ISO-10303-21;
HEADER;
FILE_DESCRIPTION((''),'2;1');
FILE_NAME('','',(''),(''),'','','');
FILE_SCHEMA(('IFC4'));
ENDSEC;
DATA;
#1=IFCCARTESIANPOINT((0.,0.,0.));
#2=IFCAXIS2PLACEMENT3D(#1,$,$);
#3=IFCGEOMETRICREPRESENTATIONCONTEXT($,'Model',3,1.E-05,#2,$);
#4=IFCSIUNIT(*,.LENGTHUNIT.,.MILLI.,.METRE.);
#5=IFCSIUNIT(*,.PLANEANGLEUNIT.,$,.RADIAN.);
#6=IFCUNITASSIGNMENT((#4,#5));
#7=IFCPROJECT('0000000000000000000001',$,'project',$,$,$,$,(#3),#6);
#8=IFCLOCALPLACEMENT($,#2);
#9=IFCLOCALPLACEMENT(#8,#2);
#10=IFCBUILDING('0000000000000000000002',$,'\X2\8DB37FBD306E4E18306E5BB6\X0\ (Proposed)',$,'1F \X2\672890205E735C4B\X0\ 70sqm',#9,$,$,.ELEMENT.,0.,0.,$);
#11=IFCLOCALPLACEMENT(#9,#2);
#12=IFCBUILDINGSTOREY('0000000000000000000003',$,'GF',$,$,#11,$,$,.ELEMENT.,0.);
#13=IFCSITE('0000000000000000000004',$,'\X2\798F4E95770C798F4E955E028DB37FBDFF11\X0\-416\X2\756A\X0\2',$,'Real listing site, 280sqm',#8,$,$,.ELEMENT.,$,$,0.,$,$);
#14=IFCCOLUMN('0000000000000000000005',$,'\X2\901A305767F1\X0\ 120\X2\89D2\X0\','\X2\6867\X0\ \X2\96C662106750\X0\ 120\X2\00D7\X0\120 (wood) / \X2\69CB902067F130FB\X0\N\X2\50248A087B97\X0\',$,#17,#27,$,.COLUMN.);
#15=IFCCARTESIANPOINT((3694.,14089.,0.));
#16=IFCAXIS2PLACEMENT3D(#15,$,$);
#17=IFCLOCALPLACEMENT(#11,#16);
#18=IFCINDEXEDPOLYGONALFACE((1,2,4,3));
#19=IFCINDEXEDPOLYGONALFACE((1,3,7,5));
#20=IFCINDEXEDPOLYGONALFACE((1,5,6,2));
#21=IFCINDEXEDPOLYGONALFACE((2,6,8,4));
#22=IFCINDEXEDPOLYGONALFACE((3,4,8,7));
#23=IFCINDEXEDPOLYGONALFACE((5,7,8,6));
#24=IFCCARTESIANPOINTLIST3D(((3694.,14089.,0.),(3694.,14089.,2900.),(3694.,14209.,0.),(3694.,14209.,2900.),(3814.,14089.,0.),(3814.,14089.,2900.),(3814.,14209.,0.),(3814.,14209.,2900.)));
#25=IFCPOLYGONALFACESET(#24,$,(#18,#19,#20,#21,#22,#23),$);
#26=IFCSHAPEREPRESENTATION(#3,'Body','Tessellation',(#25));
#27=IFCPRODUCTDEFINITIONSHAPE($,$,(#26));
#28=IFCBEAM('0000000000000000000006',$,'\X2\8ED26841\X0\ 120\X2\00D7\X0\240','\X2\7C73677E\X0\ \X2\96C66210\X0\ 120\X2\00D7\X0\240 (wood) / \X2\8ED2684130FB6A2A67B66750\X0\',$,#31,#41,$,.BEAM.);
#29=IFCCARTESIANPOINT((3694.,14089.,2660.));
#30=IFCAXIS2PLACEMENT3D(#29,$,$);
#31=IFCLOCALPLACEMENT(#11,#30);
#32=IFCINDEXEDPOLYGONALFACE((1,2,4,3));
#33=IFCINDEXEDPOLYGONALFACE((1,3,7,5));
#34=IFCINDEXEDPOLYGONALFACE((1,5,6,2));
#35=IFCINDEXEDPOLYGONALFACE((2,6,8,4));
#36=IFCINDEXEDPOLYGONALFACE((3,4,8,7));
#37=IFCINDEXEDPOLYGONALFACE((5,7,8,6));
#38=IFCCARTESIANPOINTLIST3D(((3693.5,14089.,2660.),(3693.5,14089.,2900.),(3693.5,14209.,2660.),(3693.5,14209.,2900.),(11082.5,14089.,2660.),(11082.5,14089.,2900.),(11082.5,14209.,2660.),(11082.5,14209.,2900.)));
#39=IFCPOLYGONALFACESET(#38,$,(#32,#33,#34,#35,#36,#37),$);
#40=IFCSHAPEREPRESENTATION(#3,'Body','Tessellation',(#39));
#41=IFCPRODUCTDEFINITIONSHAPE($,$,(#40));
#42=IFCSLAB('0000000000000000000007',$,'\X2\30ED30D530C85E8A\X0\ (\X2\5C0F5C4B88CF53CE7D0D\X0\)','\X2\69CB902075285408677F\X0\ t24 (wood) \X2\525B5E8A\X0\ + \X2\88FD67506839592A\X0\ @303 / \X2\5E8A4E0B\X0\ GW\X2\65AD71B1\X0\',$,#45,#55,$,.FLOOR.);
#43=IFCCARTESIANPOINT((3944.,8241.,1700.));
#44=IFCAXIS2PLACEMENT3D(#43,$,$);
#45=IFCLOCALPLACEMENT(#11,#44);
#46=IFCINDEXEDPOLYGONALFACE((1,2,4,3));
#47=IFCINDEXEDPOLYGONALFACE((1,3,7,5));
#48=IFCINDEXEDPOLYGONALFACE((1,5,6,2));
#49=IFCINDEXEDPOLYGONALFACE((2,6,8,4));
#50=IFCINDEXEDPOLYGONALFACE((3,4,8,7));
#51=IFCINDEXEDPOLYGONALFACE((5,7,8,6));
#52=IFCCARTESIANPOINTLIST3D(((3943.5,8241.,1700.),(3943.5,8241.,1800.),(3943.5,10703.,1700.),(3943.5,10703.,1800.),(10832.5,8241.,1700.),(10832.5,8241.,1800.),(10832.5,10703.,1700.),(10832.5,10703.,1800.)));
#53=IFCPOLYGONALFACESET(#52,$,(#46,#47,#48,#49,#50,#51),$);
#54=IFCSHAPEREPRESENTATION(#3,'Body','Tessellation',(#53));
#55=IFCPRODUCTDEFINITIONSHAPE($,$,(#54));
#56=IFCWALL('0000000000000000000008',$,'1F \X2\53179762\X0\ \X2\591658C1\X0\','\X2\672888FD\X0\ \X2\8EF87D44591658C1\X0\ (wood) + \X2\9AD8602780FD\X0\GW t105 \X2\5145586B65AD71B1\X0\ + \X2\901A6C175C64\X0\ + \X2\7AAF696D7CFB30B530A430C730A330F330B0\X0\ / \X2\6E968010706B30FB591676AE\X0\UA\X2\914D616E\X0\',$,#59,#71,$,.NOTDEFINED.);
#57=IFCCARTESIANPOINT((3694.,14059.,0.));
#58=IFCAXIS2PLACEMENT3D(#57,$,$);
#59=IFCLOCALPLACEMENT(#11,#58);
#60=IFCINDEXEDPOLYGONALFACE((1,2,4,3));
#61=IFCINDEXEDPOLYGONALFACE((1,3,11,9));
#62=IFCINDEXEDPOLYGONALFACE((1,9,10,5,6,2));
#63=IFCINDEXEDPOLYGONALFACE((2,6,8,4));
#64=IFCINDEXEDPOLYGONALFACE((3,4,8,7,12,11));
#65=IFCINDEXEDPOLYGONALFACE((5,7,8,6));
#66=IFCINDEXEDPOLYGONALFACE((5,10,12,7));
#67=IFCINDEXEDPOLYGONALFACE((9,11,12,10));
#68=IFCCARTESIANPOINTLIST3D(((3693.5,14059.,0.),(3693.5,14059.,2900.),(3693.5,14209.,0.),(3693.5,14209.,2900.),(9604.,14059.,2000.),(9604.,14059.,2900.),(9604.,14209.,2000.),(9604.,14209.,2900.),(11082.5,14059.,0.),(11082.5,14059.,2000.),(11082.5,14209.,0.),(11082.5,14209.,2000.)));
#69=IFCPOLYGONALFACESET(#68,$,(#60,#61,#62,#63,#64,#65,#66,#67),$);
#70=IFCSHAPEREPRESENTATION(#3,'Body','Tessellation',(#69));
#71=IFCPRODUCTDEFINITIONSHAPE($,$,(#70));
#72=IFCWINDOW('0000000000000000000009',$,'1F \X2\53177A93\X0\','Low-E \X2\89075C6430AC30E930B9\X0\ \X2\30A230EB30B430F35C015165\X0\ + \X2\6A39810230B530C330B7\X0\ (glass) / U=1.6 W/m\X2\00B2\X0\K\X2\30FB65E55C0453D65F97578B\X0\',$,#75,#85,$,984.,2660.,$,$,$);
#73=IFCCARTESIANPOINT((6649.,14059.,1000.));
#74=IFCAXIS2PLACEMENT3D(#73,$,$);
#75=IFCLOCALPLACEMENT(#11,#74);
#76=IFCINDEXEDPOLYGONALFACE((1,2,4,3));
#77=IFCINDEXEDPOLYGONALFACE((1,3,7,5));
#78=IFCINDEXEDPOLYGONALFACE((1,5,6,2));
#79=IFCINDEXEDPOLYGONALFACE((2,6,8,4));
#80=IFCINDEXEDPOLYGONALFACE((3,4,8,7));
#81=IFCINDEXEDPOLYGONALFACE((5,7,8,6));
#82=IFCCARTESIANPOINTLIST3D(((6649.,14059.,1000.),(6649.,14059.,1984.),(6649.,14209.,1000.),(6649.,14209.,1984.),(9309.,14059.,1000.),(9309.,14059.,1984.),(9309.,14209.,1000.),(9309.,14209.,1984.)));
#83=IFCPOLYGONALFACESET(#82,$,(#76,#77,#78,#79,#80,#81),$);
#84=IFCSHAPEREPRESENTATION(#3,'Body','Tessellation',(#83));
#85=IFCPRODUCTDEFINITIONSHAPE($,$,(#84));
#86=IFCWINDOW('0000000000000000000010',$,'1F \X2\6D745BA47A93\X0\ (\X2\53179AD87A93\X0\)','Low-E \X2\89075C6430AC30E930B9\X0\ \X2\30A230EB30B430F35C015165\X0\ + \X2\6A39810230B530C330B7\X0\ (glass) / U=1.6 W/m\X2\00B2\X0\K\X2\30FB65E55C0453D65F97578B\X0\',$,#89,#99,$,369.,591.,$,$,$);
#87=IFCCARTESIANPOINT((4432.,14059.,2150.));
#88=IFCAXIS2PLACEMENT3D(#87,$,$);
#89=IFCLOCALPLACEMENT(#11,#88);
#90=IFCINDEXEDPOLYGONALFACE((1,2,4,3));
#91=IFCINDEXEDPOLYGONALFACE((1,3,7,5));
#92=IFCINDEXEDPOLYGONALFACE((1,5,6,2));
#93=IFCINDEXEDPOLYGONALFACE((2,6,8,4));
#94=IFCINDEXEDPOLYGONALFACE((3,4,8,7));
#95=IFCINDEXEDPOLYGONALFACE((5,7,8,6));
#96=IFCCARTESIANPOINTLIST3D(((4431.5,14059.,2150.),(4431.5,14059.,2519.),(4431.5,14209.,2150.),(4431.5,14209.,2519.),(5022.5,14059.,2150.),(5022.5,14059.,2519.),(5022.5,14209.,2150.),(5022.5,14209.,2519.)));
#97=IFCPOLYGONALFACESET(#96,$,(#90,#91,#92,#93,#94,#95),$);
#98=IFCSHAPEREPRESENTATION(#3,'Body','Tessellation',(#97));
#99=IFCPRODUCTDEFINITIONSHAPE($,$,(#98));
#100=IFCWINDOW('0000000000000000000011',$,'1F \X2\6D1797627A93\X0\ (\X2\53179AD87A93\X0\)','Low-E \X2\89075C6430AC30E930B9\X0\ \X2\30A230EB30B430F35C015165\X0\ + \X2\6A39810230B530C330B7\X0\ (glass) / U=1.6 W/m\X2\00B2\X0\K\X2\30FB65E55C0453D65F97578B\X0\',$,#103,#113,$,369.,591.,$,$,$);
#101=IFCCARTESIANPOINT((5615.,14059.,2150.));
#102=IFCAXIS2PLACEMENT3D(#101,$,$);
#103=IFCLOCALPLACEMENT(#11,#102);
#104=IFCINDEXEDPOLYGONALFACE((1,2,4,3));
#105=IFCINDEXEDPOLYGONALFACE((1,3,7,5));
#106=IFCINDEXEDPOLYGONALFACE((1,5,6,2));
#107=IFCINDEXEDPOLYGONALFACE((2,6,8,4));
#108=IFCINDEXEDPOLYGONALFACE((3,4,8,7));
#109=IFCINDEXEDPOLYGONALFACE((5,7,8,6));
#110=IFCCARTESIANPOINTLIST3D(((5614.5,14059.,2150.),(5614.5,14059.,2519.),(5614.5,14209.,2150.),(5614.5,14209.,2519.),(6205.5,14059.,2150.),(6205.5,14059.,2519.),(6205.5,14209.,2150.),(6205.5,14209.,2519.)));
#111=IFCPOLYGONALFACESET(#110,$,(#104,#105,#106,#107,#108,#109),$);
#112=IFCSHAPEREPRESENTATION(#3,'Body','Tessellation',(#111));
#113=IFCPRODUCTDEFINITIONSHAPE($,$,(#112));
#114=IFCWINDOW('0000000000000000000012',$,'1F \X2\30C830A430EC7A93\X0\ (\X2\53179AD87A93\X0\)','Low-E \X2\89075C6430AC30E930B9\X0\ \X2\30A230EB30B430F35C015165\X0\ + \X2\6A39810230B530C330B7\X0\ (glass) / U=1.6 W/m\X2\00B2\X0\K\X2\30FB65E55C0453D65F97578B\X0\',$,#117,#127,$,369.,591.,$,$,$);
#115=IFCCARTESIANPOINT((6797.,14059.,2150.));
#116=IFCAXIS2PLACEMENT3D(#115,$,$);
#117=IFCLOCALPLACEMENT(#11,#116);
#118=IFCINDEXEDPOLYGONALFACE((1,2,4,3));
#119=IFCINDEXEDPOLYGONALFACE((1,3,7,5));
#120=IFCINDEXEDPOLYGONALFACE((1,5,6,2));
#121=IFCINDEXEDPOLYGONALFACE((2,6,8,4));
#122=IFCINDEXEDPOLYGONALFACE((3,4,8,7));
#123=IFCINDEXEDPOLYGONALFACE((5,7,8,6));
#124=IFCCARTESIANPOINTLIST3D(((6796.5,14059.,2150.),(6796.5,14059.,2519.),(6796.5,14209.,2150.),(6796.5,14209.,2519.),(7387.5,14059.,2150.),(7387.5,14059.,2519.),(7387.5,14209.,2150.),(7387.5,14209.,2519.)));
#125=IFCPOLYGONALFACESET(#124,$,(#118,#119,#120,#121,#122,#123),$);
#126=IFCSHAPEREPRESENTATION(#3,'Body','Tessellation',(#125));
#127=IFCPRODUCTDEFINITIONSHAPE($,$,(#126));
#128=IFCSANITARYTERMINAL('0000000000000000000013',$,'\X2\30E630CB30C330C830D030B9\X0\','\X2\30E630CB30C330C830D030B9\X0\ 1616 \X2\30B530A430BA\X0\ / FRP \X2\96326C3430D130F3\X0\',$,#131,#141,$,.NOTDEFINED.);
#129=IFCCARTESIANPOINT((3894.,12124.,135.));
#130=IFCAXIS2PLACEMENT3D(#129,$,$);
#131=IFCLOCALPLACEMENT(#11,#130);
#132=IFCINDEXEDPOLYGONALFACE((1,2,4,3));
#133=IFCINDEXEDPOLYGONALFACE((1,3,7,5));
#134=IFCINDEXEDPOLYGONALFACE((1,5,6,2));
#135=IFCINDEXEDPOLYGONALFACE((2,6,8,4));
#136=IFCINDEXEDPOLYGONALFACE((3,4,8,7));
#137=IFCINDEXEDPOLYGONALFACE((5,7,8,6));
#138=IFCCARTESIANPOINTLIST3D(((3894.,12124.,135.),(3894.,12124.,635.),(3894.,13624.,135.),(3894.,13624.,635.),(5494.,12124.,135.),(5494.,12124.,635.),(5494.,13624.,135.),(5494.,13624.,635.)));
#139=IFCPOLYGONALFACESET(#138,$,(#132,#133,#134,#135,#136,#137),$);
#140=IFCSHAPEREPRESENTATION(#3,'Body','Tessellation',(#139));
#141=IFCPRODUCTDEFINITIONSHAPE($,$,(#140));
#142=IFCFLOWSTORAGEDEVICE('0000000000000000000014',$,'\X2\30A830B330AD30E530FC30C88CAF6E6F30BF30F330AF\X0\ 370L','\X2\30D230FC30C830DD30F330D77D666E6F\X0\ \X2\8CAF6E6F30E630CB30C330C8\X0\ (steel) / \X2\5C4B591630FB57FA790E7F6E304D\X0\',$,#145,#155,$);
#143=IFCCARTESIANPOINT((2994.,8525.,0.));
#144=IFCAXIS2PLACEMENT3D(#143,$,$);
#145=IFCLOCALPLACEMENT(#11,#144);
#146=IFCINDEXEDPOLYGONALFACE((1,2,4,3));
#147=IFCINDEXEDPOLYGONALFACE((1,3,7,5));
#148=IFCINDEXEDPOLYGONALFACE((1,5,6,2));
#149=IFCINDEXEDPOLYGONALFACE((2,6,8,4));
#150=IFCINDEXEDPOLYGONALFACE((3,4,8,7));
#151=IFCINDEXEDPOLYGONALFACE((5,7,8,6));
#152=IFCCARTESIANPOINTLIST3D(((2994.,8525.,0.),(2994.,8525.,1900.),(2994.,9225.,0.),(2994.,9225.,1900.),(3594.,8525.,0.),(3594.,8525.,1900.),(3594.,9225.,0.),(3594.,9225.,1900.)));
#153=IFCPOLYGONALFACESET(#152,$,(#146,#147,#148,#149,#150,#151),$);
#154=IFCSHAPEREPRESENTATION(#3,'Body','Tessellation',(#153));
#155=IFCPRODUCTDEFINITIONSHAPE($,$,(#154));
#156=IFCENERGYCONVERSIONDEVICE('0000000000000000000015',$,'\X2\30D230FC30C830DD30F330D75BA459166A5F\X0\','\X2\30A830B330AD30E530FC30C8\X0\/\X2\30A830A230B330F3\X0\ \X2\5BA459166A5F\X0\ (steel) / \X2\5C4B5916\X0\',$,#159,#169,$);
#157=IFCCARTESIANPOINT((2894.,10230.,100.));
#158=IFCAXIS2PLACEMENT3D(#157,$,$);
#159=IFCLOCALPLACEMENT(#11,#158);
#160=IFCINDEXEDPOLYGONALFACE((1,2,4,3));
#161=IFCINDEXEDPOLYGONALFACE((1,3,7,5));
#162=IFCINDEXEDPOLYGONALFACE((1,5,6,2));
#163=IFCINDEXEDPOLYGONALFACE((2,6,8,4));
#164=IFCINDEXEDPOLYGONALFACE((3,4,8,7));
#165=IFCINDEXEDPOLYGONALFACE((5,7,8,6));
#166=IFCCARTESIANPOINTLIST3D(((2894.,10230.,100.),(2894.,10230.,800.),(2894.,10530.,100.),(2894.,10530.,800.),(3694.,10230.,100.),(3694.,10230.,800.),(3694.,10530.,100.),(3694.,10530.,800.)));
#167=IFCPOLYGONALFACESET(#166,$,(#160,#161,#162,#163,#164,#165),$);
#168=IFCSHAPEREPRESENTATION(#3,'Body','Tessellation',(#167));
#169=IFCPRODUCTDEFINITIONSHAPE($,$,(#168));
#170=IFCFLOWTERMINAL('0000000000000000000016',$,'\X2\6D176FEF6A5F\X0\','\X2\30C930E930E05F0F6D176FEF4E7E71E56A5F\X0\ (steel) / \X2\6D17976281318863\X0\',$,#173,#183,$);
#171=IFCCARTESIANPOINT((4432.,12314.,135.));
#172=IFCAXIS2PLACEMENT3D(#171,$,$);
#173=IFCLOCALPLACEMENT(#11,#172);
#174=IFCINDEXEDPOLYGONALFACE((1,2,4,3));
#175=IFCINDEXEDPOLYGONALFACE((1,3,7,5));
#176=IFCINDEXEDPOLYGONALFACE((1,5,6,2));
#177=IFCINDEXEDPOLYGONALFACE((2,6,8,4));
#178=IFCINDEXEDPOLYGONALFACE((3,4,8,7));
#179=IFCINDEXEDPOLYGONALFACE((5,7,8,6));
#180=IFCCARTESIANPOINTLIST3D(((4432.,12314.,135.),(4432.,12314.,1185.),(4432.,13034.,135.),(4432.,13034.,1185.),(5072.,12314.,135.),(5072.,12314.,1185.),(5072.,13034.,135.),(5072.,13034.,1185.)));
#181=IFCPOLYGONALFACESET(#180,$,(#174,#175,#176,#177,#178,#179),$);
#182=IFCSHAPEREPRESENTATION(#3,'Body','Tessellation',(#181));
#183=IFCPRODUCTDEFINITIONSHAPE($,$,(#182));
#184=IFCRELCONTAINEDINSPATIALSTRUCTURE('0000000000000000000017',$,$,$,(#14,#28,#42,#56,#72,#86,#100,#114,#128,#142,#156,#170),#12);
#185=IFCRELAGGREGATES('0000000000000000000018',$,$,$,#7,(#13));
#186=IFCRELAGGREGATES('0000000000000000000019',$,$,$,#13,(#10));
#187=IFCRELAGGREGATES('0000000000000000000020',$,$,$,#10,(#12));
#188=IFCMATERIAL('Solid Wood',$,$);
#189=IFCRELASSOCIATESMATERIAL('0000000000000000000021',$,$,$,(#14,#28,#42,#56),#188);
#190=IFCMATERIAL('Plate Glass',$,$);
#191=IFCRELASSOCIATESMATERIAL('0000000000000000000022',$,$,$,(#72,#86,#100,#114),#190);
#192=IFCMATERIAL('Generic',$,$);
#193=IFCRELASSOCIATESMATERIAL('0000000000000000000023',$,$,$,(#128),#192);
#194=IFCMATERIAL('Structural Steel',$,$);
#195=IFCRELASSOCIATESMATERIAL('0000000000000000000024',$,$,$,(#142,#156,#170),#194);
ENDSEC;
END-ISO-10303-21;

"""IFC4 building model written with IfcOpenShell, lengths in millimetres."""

from ifc_helpers import new_model, si_unit, frame, frame_2d, origin, place, context, project, spatial, rectangle, extrude, material, element, fill, save


model = new_model("IFC4")

# Units and contexts
model_context = context("Model", 3, precision=1e-05, world=origin())
ifc_project = project(units=[si_unit("LENGTHUNIT", "METRE", prefix="MILLI"), si_unit("PLANEANGLEUNIT", "RADIAN")], contexts=[model_context])

# Site, building, storey
site_placement = place(None, origin())
site = spatial("IfcSite", under=ifc_project, at=site_placement, Name="福井県福井市足羽１-416番2", ObjectType="Real listing site, 280sqm", CompositionType="ELEMENT", RefElevation=0.0)
building_placement = place(site_placement, origin())
building = spatial("IfcBuilding", under=site, at=building_placement, Name="足羽の丘の家 (Proposed)", ObjectType="1F 木造平屋 70sqm", CompositionType="ELEMENT", ElevationOfRefHeight=0.0, ElevationOfTerrain=0.0)
storey_placement = place(building_placement, origin())
storey = spatial("IfcBuildingStorey", under=building, at=storey_placement, Name="GF", CompositionType="ELEMENT", Elevation=0.0)

# Column
ifc_material_1 = material(Name="Solid Wood")
column_1_placement = place(storey_placement, frame((3694.0, 14089.0, 0.0)))
element("IfcColumn", 1, at=column_1_placement, inside=storey, material=ifc_material_1, Name="通し柱 120角", Description="桧 集成材 120×120 (wood) / 構造柱・N値計算", PredefinedType="COLUMN", context=model_context, shape_type="SweptSolid", body=[
    extrude(rectangle(XDim=120.0, YDim=120.0, at=frame_2d((60.0, 60.0))), frame((3694.0, 14089.0, 0.0)), (0.0, 0.0, 1.0), 2900.0),
])

# Beam
beam_1_placement = place(storey_placement, frame((3694.0, 14089.0, 2660.0)))
element("IfcBeam", 2, at=beam_1_placement, inside=storey, material=ifc_material_1, Name="軒桁 120×240", Description="米松 集成 120×240 (wood) / 軒桁・横架材", PredefinedType="BEAM", context=model_context, shape_type="SweptSolid", body=[
    extrude(rectangle(XDim=7389.0, YDim=120.0, at=frame_2d((3694.0, 60.0))), frame((3694.0, 14089.0, 2660.0)), (0.0, 0.0, 1.0), 240.0),
])

# Slab
slab_placement = place(storey_placement, frame((3944.0, 8241.0, 1700.0)))
element("IfcSlab", 3, at=slab_placement, inside=storey, material=ifc_material_1, Name="ロフト床 (小屋裏収納)", Description="構造用合板 t24 (wood) 剛床 + 製材根太 @303 / 床下 GW断熱", PredefinedType="FLOOR", context=model_context, shape_type="SweptSolid", body=[
    extrude(rectangle(XDim=6889.0, YDim=2462.0, at=frame_2d((3444.0, 1231.0))), frame((3944.0, 8241.0, 1700.0)), (0.0, 0.0, 1.0), 100.0),
])

# Wall, openings, windows
wall_1_placement = place(storey_placement, frame((3694.0, 14059.0, 0.0)))
wall_1 = element("IfcWall", 4, at=wall_1_placement, inside=storey, material=ifc_material_1, Name="1F 北面 外壁", Description="木製 軸組外壁 (wood) + 高性能GW t105 充填断熱 + 通気層 + 窯業系サイディング / 準耐火・外皮UA配慮", PredefinedType="NOTDEFINED", context=model_context, shape_type="SweptSolid", body=[
    extrude(rectangle(XDim=7389.0, YDim=150.0, at=frame_2d((3694.0, 75.0))), frame((3694.0, 14059.0, 0.0)), (0.0, 0.0, 1.0), 2900.0),
])
opening_1_placement = place(storey_placement, frame((6649.0, 14059.0, 1000.0)))
opening_1 = element("IfcOpeningElement", 5, at=opening_1_placement, cuts=wall_1, PredefinedType="NOTDEFINED", context=model_context, shape_type="SweptSolid", body=[
    extrude(rectangle(XDim=2660.0, YDim=150.0, at=frame_2d((1330.0, 75.0))), frame((6649.0, 14059.0, 1000.0)), (0.0, 0.0, 1.0), 984.0),
])
opening_2_placement = place(storey_placement, frame((4432.0, 14059.0, 2150.0)))
opening_2 = element("IfcOpeningElement", 6, at=opening_2_placement, cuts=wall_1, PredefinedType="NOTDEFINED", context=model_context, shape_type="SweptSolid", body=[
    extrude(rectangle(XDim=591.0, YDim=150.0, at=frame_2d((295.0, 75.0))), frame((4432.0, 14059.0, 2150.0)), (0.0, 0.0, 1.0), 369.0),
])
opening_3_placement = place(storey_placement, frame((5615.0, 14059.0, 2150.0)))
opening_3 = element("IfcOpeningElement", 7, at=opening_3_placement, cuts=wall_1, PredefinedType="NOTDEFINED", context=model_context, shape_type="SweptSolid", body=[
    extrude(rectangle(XDim=591.0, YDim=150.0, at=frame_2d((295.0, 75.0))), frame((5615.0, 14059.0, 2150.0)), (0.0, 0.0, 1.0), 369.0),
])
opening_4_placement = place(storey_placement, frame((6797.0, 14059.0, 2150.0)))
opening_4 = element("IfcOpeningElement", 8, at=opening_4_placement, cuts=wall_1, PredefinedType="NOTDEFINED", context=model_context, shape_type="SweptSolid", body=[
    extrude(rectangle(XDim=591.0, YDim=150.0, at=frame_2d((295.0, 75.0))), frame((6797.0, 14059.0, 2150.0)), (0.0, 0.0, 1.0), 369.0),
])
ifc_material_2 = material(Name="Plate Glass")
window_1_placement = place(storey_placement, frame((6649.0, 14059.0, 1000.0)))
window_1 = element("IfcWindow", 9, at=window_1_placement, inside=storey, material=ifc_material_2, Name="1F 北窓", Description="Low-E 複層ガラス アルゴン封入 + 樹脂サッシ (glass) / U=1.6 W/m²K・日射取得型", OverallHeight=984.0, OverallWidth=2660.0, context=model_context, shape_type="SweptSolid", body=[
    extrude(rectangle(XDim=2660.0, YDim=150.0, at=frame_2d((1330.0, 75.0))), frame((6649.0, 14059.0, 1000.0)), (0.0, 0.0, 1.0), 984.0),
])
fill(opening_1, window_1)
window_2_placement = place(storey_placement, frame((4432.0, 14059.0, 2150.0)))
window_2 = element("IfcWindow", 10, at=window_2_placement, inside=storey, material=ifc_material_2, Name="1F 浴室窓 (北高窓)", Description="Low-E 複層ガラス アルゴン封入 + 樹脂サッシ (glass) / U=1.6 W/m²K・日射取得型", OverallHeight=369.0, OverallWidth=591.0, context=model_context, shape_type="SweptSolid", body=[
    extrude(rectangle(XDim=591.0, YDim=150.0, at=frame_2d((295.0, 75.0))), frame((4432.0, 14059.0, 2150.0)), (0.0, 0.0, 1.0), 369.0),
])
fill(opening_2, window_2)
window_3_placement = place(storey_placement, frame((5615.0, 14059.0, 2150.0)))
window_3 = element("IfcWindow", 11, at=window_3_placement, inside=storey, material=ifc_material_2, Name="1F 洗面窓 (北高窓)", Description="Low-E 複層ガラス アルゴン封入 + 樹脂サッシ (glass) / U=1.6 W/m²K・日射取得型", OverallHeight=369.0, OverallWidth=591.0, context=model_context, shape_type="SweptSolid", body=[
    extrude(rectangle(XDim=591.0, YDim=150.0, at=frame_2d((295.0, 75.0))), frame((5615.0, 14059.0, 2150.0)), (0.0, 0.0, 1.0), 369.0),
])
fill(opening_3, window_3)
window_4_placement = place(storey_placement, frame((6797.0, 14059.0, 2150.0)))
window_4 = element("IfcWindow", 12, at=window_4_placement, inside=storey, material=ifc_material_2, Name="1F トイレ窓 (北高窓)", Description="Low-E 複層ガラス アルゴン封入 + 樹脂サッシ (glass) / U=1.6 W/m²K・日射取得型", OverallHeight=369.0, OverallWidth=591.0, context=model_context, shape_type="SweptSolid", body=[
    extrude(rectangle(XDim=591.0, YDim=150.0, at=frame_2d((295.0, 75.0))), frame((6797.0, 14059.0, 2150.0)), (0.0, 0.0, 1.0), 369.0),
])
fill(opening_4, window_4)

# Shared definitions
ifc_material_3 = material(Name="Structural Steel")

# Sanitary terminal
ifc_material_4 = material(Name="Generic")
sanitary_terminal_placement = place(storey_placement, frame((3894.0, 12124.0, 135.0)))
element("IfcSanitaryTerminal", 13, at=sanitary_terminal_placement, inside=storey, material=ifc_material_4, Name="ユニットバス", Description="ユニットバス 1616 サイズ / FRP 防水パン", PredefinedType="NOTDEFINED", context=model_context, shape_type="SweptSolid", body=[
    extrude(rectangle(XDim=1600.0, YDim=1500.0, at=frame_2d((800.0, 750.0))), frame((3894.0, 12124.0, 135.0)), (0.0, 0.0, 1.0), 500.0),
])

# Flow storage device
flow_storage_device_placement = place(storey_placement, frame((2994.0, 8525.0, 0.0)))
element("IfcFlowStorageDevice", 14, at=flow_storage_device_placement, inside=storey, material=ifc_material_3, Name="エコキュート貯湯タンク 370L", Description="ヒートポンプ給湯 貯湯ユニット (steel) / 屋外・基礎置き", context=model_context, shape_type="SweptSolid", body=[
    extrude(rectangle(XDim=600.0, YDim=700.0, at=frame_2d((300.0, 350.0))), frame((2994.0, 8525.0, 0.0)), (0.0, 0.0, 1.0), 1900.0),
])

# Energy conversion device
energy_conversion_device_placement = place(storey_placement, frame((2894.0, 10230.0, 100.0)))
element("IfcEnergyConversionDevice", 15, at=energy_conversion_device_placement, inside=storey, material=ifc_material_3, Name="ヒートポンプ室外機", Description="エコキュート/エアコン 室外機 (steel) / 屋外", context=model_context, shape_type="SweptSolid", body=[
    extrude(rectangle(XDim=800.0, YDim=300.0, at=frame_2d((400.0, 150.0))), frame((2894.0, 10230.0, 100.0)), (0.0, 0.0, 1.0), 700.0),
])

# Flow terminal
flow_terminal_placement = place(storey_placement, frame((4432.0, 12314.0, 135.0)))
element("IfcFlowTerminal", 16, at=flow_terminal_placement, inside=storey, material=ifc_material_3, Name="洗濯機", Description="ドラム式洗濯乾燥機 (steel) / 洗面脱衣", context=model_context, shape_type="SweptSolid", body=[
    extrude(rectangle(XDim=640.0, YDim=720.0, at=frame_2d((320.0, 360.0))), frame((4432.0, 12314.0, 135.0)), (0.0, 0.0, 1.0), 1050.0),
])

save(model, "model.ifc")
